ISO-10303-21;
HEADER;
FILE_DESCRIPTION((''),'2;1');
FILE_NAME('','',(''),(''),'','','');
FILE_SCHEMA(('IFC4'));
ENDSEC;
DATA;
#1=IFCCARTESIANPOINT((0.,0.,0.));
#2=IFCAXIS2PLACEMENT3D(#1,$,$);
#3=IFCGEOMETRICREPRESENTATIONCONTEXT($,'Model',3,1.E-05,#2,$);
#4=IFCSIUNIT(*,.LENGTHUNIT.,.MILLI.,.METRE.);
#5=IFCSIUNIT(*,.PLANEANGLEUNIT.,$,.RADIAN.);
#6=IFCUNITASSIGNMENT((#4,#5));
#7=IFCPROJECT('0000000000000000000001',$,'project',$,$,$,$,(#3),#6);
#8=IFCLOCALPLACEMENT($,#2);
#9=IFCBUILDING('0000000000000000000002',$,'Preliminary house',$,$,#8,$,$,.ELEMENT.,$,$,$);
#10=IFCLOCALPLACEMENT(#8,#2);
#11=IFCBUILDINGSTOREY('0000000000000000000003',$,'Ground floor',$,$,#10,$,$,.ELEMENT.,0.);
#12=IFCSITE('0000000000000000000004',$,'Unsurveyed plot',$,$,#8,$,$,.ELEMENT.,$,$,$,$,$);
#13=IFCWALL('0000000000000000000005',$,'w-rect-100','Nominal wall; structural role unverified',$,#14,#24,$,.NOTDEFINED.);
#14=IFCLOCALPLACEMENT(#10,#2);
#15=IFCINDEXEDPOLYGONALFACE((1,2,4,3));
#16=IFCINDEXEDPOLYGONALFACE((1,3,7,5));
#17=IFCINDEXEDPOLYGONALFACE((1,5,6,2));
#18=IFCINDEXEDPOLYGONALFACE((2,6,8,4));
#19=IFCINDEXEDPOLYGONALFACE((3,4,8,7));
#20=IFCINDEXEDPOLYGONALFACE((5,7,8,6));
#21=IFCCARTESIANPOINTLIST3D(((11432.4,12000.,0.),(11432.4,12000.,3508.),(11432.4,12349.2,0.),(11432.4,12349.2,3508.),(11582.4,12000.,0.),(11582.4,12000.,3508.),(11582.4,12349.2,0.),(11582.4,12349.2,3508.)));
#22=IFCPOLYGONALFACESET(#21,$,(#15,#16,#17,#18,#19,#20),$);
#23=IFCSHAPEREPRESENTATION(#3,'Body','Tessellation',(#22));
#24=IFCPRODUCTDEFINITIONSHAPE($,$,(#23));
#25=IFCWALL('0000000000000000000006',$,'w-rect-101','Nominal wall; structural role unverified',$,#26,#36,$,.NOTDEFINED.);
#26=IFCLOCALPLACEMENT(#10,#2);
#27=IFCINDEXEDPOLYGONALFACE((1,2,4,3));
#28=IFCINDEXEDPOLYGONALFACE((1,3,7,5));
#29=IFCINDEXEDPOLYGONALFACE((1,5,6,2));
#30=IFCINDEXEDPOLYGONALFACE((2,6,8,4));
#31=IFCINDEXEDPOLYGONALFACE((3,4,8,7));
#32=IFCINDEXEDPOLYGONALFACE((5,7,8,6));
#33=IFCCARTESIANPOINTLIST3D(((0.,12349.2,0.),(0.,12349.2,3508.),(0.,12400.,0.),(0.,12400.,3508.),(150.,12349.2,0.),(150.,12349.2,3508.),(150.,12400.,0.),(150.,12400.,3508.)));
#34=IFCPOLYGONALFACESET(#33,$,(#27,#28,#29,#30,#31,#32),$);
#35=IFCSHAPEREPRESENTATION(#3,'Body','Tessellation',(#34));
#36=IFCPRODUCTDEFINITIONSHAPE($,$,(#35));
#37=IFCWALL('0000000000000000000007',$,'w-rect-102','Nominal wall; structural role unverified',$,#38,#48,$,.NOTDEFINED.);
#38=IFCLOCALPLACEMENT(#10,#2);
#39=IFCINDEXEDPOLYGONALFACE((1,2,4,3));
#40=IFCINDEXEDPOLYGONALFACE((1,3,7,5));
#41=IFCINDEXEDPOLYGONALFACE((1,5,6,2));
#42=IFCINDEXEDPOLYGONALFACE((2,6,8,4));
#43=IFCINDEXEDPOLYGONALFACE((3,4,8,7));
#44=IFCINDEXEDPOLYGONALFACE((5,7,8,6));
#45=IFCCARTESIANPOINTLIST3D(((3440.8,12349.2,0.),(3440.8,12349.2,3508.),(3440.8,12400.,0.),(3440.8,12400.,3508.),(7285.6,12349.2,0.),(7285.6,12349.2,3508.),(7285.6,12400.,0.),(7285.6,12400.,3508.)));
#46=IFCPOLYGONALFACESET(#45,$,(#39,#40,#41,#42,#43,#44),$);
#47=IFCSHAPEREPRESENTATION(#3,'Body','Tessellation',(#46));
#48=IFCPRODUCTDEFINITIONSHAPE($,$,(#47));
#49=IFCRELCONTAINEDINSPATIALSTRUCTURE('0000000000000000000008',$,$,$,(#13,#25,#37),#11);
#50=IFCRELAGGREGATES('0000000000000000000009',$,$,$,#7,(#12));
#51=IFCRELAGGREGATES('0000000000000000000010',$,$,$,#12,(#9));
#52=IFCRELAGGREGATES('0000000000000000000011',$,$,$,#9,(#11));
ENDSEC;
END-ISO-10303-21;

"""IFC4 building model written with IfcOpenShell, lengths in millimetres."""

from ifc_helpers import new_model, si_unit, origin, place, context, project, spatial, polyline, outline, extrude, element, save


model = new_model("IFC4")

# Units and contexts
model_context = context("Model", 3, precision=1e-05, world=origin())
ifc_project = project(units=[si_unit("LENGTHUNIT", "METRE", prefix="MILLI"), si_unit("PLANEANGLEUNIT", "RADIAN")], contexts=[model_context])

# Site, building, storey
placement_1 = place(None, origin())
site = spatial("IfcSite", under=ifc_project, at=placement_1, Name="Unsurveyed plot", CompositionType="ELEMENT")
building = spatial("IfcBuilding", under=site, at=placement_1, Name="Preliminary house", CompositionType="ELEMENT")
placement_2 = place(placement_1, origin())
storey = spatial("IfcBuildingStorey", under=building, at=placement_2, Name="Ground floor", CompositionType="ELEMENT", Elevation=0.0)

# Walls
element("IfcWall", 1, at=placement_2, inside=storey, Name="w-rect-100", Description="Nominal wall; structural role unverified", PredefinedType="NOTDEFINED", context=model_context, shape_type="SweptSolid", body=[
    extrude(outline(polyline([(11432.4, 12000.0), (11582.4, 12000.0), (11582.4, 12349.2), (11432.4, 12349.2), (11432.4, 12000.0)])), origin(), (0.0, 0.0, 1.0), 3508.0),
])
element("IfcWall", 2, at=placement_2, inside=storey, Name="w-rect-101", Description="Nominal wall; structural role unverified", PredefinedType="NOTDEFINED", context=model_context, shape_type="SweptSolid", body=[
    extrude(outline(polyline([(0.0, 12349.2), (150.0, 12349.2), (150.0, 12400.0), (0.0, 12400.0), (0.0, 12349.2)])), origin(), (0.0, 0.0, 1.0), 3508.0),
])
element("IfcWall", 3, at=placement_2, inside=storey, Name="w-rect-102", Description="Nominal wall; structural role unverified", PredefinedType="NOTDEFINED", context=model_context, shape_type="SweptSolid", body=[
    extrude(outline(polyline([(3440.8, 12349.2), (7285.6, 12349.2), (7285.6, 12400.0), (3440.8, 12400.0), (3440.8, 12349.2)])), origin(), (0.0, 0.0, 1.0), 3508.0),
])

save(model, "model.ifc")
